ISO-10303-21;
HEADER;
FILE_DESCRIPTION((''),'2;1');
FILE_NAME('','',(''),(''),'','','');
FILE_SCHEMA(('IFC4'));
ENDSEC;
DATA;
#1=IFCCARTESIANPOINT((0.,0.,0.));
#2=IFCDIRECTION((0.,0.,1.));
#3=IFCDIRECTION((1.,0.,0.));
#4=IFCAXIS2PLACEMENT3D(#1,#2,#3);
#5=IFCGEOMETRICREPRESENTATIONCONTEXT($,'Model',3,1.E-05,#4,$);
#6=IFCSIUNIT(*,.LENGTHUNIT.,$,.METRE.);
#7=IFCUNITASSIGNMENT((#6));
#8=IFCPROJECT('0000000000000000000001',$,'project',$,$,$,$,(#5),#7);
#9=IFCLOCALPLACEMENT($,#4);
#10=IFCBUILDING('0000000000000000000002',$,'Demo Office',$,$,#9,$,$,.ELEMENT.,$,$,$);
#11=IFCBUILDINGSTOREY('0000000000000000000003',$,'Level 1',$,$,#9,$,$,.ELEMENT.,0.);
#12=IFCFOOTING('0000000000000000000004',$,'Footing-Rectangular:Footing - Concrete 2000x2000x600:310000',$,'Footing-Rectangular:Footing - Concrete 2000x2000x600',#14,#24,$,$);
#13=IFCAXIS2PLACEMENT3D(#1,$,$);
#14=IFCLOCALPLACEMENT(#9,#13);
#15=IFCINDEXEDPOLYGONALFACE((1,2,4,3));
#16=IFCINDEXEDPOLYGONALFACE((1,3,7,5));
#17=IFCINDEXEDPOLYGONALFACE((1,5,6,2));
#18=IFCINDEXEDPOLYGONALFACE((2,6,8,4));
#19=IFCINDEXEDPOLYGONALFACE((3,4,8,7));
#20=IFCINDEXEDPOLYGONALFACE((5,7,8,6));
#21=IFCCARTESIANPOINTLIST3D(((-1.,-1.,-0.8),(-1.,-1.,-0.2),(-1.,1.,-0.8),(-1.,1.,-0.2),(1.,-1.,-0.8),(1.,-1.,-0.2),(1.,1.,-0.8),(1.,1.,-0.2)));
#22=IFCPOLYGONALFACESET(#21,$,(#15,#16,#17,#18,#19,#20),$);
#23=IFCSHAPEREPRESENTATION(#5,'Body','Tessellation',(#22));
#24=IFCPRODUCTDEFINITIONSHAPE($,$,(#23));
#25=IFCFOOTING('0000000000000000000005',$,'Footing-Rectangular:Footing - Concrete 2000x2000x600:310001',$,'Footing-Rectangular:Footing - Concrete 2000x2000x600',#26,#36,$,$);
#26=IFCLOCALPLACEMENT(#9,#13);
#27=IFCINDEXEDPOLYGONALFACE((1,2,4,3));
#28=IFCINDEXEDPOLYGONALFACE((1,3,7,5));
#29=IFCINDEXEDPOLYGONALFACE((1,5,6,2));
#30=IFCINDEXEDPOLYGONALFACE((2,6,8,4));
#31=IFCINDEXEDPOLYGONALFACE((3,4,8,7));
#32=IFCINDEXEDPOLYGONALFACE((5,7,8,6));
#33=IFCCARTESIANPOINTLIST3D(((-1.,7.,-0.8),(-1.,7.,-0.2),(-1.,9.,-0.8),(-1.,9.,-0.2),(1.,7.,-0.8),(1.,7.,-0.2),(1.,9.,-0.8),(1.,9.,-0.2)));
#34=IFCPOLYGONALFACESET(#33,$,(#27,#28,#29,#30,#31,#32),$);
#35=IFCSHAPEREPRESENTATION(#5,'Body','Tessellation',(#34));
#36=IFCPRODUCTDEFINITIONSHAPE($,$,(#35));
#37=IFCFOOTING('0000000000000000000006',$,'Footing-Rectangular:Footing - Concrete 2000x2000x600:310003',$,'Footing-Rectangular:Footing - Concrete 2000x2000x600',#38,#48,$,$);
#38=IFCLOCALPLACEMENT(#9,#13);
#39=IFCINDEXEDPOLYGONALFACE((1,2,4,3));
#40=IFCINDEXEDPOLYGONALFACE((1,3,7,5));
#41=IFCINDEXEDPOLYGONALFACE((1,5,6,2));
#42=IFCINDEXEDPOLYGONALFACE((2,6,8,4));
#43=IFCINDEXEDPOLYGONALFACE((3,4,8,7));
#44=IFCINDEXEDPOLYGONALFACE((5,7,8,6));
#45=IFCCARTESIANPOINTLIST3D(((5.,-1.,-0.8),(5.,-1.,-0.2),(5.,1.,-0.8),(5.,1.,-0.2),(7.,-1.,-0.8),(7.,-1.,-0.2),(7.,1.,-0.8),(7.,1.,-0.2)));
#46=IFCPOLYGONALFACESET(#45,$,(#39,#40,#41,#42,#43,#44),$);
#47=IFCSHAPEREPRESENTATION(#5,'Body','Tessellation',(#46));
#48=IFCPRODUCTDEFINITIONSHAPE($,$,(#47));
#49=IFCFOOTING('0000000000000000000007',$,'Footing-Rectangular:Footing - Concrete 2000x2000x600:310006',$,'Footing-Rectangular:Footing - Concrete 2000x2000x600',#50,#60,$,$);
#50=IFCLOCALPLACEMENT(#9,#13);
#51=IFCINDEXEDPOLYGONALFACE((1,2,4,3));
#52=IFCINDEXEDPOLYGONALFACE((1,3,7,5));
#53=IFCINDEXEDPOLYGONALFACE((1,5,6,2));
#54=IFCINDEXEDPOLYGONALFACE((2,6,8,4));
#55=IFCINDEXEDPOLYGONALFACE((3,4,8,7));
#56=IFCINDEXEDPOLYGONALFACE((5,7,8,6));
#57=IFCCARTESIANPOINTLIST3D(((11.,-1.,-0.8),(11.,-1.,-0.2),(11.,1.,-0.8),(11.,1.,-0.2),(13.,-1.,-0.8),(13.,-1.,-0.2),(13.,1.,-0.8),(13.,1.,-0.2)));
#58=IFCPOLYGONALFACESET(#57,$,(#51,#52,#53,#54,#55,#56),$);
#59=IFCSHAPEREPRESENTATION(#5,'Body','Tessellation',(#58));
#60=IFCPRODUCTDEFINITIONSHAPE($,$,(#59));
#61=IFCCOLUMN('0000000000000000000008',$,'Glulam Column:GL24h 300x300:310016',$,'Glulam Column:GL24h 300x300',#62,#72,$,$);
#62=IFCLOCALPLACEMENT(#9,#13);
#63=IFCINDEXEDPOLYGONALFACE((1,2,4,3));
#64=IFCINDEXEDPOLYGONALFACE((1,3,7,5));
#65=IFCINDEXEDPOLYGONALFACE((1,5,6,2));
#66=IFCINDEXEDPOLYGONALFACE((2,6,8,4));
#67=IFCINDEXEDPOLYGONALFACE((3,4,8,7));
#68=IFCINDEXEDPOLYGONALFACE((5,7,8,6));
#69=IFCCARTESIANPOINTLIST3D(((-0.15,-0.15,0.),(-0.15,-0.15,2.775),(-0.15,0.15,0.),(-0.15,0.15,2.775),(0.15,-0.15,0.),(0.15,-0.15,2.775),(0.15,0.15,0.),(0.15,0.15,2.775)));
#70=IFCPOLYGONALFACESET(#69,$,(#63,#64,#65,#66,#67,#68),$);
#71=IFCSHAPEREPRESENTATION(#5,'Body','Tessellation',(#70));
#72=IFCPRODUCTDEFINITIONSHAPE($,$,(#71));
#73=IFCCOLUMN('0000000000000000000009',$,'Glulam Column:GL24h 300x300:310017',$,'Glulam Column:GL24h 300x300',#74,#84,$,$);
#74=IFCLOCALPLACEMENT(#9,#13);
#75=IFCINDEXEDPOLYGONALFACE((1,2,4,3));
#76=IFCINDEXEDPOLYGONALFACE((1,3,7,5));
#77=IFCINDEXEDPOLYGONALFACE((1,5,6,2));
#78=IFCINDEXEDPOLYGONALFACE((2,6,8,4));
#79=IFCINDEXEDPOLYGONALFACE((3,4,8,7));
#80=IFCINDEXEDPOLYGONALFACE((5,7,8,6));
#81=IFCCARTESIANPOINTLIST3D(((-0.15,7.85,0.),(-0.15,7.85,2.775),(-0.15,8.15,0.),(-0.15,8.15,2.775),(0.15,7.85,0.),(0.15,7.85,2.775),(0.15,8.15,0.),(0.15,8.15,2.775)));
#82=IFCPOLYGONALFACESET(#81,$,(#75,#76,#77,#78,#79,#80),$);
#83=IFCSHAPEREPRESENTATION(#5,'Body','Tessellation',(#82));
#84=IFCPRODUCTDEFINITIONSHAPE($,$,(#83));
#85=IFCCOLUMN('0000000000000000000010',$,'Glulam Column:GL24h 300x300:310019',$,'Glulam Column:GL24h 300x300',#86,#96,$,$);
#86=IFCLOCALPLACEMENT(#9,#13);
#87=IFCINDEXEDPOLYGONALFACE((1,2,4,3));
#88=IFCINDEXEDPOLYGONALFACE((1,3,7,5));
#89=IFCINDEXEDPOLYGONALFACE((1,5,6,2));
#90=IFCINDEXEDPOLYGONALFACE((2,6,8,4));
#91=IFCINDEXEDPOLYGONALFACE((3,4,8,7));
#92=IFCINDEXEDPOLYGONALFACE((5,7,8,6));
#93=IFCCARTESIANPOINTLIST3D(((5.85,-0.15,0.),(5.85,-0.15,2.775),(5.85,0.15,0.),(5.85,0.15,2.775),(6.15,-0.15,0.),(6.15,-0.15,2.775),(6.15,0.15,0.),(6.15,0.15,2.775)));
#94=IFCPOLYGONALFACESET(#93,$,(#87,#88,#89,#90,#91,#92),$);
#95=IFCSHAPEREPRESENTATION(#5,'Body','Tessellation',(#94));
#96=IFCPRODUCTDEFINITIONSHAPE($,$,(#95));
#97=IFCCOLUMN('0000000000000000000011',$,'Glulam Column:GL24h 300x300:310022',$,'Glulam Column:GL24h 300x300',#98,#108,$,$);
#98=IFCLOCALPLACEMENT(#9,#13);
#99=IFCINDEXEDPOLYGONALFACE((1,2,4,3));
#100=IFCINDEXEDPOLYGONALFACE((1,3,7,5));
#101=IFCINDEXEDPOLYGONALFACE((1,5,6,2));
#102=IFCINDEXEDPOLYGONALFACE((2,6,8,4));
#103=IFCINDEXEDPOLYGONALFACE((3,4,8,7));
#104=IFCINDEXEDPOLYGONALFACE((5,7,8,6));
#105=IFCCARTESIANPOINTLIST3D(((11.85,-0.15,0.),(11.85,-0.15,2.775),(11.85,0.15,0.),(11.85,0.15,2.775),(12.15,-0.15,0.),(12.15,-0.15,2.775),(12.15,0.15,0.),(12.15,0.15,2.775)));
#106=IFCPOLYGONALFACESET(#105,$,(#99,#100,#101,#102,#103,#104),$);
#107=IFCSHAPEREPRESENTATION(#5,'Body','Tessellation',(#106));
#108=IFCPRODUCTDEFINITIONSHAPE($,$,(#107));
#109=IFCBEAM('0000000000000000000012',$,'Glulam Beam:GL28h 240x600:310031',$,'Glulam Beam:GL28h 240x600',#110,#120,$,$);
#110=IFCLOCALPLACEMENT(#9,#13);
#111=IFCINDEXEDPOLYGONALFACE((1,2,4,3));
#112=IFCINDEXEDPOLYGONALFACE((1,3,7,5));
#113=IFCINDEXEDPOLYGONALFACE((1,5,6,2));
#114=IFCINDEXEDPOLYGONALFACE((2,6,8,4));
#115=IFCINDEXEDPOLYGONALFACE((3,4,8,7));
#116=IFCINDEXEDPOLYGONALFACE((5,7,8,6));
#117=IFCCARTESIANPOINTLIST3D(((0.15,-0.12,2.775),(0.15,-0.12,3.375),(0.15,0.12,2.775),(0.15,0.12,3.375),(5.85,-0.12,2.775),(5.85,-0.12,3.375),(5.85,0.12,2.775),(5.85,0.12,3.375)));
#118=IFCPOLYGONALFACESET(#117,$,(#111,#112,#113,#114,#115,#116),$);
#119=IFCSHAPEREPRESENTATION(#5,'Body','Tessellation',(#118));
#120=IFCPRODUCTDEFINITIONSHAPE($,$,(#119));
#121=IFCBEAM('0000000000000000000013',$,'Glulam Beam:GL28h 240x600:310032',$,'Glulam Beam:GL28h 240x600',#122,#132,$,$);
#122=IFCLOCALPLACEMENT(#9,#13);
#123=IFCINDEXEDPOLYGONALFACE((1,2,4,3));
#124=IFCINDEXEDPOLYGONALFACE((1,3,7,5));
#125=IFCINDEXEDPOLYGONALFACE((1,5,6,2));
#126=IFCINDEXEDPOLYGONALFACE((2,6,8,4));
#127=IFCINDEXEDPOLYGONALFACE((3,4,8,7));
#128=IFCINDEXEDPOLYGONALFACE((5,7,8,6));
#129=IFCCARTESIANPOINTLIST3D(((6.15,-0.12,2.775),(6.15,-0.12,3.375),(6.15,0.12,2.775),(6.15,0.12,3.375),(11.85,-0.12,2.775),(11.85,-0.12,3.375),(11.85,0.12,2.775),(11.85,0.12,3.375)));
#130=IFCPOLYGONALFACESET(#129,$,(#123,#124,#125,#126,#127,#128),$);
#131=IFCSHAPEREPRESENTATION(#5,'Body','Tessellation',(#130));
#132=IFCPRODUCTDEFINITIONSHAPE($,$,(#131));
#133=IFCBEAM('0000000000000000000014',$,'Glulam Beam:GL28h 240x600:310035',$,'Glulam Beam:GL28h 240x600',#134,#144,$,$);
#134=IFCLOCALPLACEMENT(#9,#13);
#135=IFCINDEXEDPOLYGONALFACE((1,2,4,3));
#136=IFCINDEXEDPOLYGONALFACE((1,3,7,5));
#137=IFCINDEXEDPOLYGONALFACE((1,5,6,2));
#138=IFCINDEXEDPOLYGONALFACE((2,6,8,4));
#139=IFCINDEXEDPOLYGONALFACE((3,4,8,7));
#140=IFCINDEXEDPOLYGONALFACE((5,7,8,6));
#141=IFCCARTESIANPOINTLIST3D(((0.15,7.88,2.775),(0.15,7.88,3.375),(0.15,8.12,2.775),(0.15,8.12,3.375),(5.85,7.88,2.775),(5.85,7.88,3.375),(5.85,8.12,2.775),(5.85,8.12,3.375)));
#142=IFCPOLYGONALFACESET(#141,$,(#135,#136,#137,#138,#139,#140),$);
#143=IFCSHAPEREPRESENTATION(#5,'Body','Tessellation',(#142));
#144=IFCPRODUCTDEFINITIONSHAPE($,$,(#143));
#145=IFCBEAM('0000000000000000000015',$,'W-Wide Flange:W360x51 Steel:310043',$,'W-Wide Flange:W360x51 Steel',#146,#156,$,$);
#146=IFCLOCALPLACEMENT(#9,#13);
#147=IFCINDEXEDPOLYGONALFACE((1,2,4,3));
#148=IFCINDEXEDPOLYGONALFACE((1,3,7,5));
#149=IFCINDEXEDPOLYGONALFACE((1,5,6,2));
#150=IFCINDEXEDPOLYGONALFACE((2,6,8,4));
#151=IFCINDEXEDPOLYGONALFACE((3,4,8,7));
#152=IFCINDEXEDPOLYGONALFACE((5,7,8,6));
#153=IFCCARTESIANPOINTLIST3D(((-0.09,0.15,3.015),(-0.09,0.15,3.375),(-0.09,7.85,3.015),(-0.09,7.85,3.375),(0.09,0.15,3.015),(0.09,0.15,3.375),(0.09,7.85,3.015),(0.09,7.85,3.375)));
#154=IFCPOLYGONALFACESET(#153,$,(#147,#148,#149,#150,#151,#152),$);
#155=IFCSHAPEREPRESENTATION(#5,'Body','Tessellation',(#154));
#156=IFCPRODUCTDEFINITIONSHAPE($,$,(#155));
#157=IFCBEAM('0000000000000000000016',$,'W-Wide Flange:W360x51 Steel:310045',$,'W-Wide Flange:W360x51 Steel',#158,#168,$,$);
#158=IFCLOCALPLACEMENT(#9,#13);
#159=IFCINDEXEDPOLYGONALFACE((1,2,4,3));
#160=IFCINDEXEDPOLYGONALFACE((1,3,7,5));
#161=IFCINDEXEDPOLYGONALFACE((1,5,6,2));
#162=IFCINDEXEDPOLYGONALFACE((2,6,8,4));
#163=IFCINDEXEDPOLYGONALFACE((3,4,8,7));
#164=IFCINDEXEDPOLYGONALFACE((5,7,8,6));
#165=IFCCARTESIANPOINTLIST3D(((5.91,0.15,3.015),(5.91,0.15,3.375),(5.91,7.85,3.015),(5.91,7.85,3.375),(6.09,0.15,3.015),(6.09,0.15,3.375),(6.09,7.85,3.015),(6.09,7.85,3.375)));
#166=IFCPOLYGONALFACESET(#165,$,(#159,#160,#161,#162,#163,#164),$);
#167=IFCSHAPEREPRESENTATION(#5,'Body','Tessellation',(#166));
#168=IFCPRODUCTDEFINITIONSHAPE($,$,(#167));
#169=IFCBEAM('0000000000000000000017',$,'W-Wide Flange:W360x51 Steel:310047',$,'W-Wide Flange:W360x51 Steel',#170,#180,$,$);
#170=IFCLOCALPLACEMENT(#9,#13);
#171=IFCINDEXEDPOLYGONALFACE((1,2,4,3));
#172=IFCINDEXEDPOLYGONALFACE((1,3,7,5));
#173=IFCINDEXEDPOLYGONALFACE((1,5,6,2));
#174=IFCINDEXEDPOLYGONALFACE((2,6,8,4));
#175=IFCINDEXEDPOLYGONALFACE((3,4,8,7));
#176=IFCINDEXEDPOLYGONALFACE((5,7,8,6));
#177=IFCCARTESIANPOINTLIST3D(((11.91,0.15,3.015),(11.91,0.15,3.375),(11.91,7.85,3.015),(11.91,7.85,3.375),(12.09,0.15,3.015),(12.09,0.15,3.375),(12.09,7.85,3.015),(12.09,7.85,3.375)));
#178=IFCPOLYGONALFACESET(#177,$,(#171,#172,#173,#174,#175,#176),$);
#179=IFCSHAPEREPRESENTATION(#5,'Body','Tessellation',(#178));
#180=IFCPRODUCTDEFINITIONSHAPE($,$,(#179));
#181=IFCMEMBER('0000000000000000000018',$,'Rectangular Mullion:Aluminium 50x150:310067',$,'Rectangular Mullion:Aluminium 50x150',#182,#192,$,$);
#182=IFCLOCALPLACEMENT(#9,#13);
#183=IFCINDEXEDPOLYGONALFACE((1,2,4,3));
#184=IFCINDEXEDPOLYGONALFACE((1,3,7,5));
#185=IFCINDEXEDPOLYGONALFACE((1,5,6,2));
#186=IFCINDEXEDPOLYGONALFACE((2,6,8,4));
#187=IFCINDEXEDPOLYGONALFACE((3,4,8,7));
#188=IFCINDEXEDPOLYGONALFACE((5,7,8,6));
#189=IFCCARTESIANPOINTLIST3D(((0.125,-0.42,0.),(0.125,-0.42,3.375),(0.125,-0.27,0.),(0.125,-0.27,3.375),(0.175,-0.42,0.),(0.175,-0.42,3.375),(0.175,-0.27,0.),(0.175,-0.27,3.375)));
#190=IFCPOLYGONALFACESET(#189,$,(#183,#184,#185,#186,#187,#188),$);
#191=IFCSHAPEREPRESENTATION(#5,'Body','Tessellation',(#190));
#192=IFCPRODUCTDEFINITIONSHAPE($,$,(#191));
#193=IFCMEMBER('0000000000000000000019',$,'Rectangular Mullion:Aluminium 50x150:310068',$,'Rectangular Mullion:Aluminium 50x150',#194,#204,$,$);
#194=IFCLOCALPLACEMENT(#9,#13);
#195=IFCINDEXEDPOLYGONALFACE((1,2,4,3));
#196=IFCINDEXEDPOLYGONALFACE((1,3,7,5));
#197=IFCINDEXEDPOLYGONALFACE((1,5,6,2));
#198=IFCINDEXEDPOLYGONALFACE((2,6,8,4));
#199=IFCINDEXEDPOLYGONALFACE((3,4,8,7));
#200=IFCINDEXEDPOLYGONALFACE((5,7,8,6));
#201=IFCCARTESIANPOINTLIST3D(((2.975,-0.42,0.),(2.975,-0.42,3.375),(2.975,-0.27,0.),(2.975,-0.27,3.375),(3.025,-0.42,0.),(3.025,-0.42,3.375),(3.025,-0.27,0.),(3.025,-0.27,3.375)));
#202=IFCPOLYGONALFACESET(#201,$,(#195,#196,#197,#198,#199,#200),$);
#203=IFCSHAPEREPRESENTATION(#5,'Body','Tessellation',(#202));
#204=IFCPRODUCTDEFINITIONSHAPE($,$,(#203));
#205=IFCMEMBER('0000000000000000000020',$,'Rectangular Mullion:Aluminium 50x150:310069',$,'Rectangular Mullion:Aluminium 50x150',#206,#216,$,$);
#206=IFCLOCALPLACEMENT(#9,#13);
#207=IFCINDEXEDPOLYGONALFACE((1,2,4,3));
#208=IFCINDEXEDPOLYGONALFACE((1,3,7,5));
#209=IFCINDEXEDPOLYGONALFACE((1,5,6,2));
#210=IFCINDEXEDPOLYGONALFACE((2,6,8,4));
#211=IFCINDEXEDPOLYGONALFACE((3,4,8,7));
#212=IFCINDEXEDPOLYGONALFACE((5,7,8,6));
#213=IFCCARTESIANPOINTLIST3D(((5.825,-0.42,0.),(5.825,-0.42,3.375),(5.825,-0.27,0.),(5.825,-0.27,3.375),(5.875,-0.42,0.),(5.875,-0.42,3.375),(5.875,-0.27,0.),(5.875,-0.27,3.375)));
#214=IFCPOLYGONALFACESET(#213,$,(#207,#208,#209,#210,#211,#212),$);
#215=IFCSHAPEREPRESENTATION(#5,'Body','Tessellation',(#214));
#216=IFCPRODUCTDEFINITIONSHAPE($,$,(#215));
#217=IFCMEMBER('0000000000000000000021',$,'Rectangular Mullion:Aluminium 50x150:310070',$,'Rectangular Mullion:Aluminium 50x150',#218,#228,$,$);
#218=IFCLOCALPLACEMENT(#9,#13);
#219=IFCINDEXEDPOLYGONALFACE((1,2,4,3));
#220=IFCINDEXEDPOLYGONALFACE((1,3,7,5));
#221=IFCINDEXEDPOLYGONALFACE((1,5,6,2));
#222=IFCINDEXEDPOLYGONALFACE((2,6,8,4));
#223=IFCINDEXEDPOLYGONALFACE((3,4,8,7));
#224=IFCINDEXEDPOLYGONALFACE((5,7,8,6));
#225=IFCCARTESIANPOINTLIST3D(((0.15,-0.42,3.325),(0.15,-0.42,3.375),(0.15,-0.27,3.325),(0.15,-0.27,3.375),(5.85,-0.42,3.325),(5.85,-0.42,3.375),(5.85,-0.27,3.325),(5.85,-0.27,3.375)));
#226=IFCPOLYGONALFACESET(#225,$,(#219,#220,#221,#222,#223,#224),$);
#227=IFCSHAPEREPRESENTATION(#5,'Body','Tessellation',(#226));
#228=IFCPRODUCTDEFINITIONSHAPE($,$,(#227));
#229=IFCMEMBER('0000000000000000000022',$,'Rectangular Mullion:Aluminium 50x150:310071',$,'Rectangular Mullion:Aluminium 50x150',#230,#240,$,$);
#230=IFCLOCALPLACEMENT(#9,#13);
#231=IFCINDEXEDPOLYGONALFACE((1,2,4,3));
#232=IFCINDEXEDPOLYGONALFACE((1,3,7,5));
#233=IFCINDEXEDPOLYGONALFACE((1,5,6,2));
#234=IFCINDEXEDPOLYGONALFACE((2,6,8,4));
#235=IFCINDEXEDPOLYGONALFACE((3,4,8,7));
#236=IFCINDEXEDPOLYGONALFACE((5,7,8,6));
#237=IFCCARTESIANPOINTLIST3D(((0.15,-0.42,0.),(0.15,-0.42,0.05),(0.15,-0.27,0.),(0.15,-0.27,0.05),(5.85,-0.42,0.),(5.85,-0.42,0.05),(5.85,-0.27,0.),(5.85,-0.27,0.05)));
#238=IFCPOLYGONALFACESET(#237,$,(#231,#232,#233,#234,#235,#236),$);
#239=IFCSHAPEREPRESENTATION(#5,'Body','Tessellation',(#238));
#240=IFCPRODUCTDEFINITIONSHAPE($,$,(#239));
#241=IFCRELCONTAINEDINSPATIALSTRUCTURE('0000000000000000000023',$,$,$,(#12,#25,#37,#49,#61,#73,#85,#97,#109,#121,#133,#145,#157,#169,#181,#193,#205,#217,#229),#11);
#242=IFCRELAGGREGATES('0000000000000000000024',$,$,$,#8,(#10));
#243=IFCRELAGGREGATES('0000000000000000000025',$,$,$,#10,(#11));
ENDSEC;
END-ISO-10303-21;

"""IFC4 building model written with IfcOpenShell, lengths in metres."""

from ifc_helpers import new_model, si_unit, frame, origin_with_axes, origin_2d, place, context, project, spatial, rectangle, extrude, element, save


model = new_model("IFC4")

# Units and contexts
model_context = context("Model", 3, precision=1e-05, world=origin_with_axes())
ifc_project = project(units=[si_unit("LENGTHUNIT", "METRE")], contexts=[model_context])

# Building, storey
placement = place(None, origin_with_axes())
building = spatial("IfcBuilding", under=ifc_project, at=placement, Name="Demo Office", CompositionType="ELEMENT")
storey = spatial("IfcBuildingStorey", under=building, at=placement, Name="Level 1", CompositionType="ELEMENT", Elevation=0.0)

# Footings
for number, where, name in (
    (1, (0.0, 0.0, -0.8), "Footing-Rectangular:Footing - Concrete 2000x2000x600:310000"),
    (2, (0.0, 8.0, -0.8), "Footing-Rectangular:Footing - Concrete 2000x2000x600:310001"),
    (3, (6.0, 0.0, -0.8), "Footing-Rectangular:Footing - Concrete 2000x2000x600:310003"),
    (4, (12.0, 0.0, -0.8), "Footing-Rectangular:Footing - Concrete 2000x2000x600:310006"),
):
    element("IfcFooting", number, at=place(placement, frame(where)), inside=storey, Name=name, ObjectType="Footing-Rectangular:Footing - Concrete 2000x2000x600", context=model_context, shape_type="SweptSolid", body=[
        extrude(rectangle(XDim=2.0, YDim=2.0, at=origin_2d()), origin_with_axes(), (0.0, 0.0, 1.0), 0.6),
    ])

# Columns
for number, where, name in (
    (5, (0.0, 0.0, 0.0), "Glulam Column:GL24h 300x300:310016"),
    (6, (0.0, 8.0, 0.0), "Glulam Column:GL24h 300x300:310017"),
    (7, (6.0, 0.0, 0.0), "Glulam Column:GL24h 300x300:310019"),
    (8, (12.0, 0.0, 0.0), "Glulam Column:GL24h 300x300:310022"),
):
    element("IfcColumn", number, at=place(placement, frame(where)), inside=storey, Name=name, ObjectType="Glulam Column:GL24h 300x300", context=model_context, shape_type="SweptSolid", body=[
        extrude(rectangle(XDim=0.3, YDim=0.3, at=origin_2d()), origin_with_axes(), (0.0, 0.0, 1.0), 2.775),
    ])

# Beams
for number, where, name in (
    (9, (3.0, 0.0, 2.775), "Glulam Beam:GL28h 240x600:310031"),
    (10, (9.0, 0.0, 2.775), "Glulam Beam:GL28h 240x600:310032"),
    (11, (3.0, 8.0, 2.775), "Glulam Beam:GL28h 240x600:310035"),
):
    element("IfcBeam", number, at=place(placement, frame(where)), inside=storey, Name=name, ObjectType="Glulam Beam:GL28h 240x600", context=model_context, shape_type="SweptSolid", body=[
        extrude(rectangle(XDim=5.7, YDim=0.24, at=origin_2d()), origin_with_axes(), (0.0, 0.0, 1.0), 0.6),
    ])
for number, where, name in (
    (12, (0.0, 4.0, 3.015), "W-Wide Flange:W360x51 Steel:310043"),
    (13, (6.0, 4.0, 3.015), "W-Wide Flange:W360x51 Steel:310045"),
    (14, (12.0, 4.0, 3.015), "W-Wide Flange:W360x51 Steel:310047"),
):
    element("IfcBeam", number, at=place(placement, frame(where)), inside=storey, Name=name, ObjectType="W-Wide Flange:W360x51 Steel", context=model_context, shape_type="SweptSolid", body=[
        extrude(rectangle(XDim=0.18, YDim=7.7, at=origin_2d()), origin_with_axes(), (0.0, 0.0, 1.0), 0.36),
    ])

# Members
for number, where, name in (
    (15, (0.15, -0.345, 0.0), "Rectangular Mullion:Aluminium 50x150:310067"),
    (16, (3.0, -0.345, 0.0), "Rectangular Mullion:Aluminium 50x150:310068"),
    (17, (5.85, -0.345, 0.0), "Rectangular Mullion:Aluminium 50x150:310069"),
):
    element("IfcMember", number, at=place(placement, frame(where)), inside=storey, Name=name, ObjectType="Rectangular Mullion:Aluminium 50x150", context=model_context, shape_type="SweptSolid", body=[
        extrude(rectangle(XDim=0.05, YDim=0.15, at=origin_2d()), origin_with_axes(), (0.0, 0.0, 1.0), 3.375),
    ])
for number, where, name in (
    (18, (3.0, -0.345, 3.325), "Rectangular Mullion:Aluminium 50x150:310070"),
    (19, (3.0, -0.345, 0.0), "Rectangular Mullion:Aluminium 50x150:310071"),
):
    element("IfcMember", number, at=place(placement, frame(where)), inside=storey, Name=name, ObjectType="Rectangular Mullion:Aluminium 50x150", context=model_context, shape_type="SweptSolid", body=[
        extrude(rectangle(XDim=5.7, YDim=0.15, at=origin_2d()), origin_with_axes(), (0.0, 0.0, 1.0), 0.05),
    ])

save(model, "model.ifc")
